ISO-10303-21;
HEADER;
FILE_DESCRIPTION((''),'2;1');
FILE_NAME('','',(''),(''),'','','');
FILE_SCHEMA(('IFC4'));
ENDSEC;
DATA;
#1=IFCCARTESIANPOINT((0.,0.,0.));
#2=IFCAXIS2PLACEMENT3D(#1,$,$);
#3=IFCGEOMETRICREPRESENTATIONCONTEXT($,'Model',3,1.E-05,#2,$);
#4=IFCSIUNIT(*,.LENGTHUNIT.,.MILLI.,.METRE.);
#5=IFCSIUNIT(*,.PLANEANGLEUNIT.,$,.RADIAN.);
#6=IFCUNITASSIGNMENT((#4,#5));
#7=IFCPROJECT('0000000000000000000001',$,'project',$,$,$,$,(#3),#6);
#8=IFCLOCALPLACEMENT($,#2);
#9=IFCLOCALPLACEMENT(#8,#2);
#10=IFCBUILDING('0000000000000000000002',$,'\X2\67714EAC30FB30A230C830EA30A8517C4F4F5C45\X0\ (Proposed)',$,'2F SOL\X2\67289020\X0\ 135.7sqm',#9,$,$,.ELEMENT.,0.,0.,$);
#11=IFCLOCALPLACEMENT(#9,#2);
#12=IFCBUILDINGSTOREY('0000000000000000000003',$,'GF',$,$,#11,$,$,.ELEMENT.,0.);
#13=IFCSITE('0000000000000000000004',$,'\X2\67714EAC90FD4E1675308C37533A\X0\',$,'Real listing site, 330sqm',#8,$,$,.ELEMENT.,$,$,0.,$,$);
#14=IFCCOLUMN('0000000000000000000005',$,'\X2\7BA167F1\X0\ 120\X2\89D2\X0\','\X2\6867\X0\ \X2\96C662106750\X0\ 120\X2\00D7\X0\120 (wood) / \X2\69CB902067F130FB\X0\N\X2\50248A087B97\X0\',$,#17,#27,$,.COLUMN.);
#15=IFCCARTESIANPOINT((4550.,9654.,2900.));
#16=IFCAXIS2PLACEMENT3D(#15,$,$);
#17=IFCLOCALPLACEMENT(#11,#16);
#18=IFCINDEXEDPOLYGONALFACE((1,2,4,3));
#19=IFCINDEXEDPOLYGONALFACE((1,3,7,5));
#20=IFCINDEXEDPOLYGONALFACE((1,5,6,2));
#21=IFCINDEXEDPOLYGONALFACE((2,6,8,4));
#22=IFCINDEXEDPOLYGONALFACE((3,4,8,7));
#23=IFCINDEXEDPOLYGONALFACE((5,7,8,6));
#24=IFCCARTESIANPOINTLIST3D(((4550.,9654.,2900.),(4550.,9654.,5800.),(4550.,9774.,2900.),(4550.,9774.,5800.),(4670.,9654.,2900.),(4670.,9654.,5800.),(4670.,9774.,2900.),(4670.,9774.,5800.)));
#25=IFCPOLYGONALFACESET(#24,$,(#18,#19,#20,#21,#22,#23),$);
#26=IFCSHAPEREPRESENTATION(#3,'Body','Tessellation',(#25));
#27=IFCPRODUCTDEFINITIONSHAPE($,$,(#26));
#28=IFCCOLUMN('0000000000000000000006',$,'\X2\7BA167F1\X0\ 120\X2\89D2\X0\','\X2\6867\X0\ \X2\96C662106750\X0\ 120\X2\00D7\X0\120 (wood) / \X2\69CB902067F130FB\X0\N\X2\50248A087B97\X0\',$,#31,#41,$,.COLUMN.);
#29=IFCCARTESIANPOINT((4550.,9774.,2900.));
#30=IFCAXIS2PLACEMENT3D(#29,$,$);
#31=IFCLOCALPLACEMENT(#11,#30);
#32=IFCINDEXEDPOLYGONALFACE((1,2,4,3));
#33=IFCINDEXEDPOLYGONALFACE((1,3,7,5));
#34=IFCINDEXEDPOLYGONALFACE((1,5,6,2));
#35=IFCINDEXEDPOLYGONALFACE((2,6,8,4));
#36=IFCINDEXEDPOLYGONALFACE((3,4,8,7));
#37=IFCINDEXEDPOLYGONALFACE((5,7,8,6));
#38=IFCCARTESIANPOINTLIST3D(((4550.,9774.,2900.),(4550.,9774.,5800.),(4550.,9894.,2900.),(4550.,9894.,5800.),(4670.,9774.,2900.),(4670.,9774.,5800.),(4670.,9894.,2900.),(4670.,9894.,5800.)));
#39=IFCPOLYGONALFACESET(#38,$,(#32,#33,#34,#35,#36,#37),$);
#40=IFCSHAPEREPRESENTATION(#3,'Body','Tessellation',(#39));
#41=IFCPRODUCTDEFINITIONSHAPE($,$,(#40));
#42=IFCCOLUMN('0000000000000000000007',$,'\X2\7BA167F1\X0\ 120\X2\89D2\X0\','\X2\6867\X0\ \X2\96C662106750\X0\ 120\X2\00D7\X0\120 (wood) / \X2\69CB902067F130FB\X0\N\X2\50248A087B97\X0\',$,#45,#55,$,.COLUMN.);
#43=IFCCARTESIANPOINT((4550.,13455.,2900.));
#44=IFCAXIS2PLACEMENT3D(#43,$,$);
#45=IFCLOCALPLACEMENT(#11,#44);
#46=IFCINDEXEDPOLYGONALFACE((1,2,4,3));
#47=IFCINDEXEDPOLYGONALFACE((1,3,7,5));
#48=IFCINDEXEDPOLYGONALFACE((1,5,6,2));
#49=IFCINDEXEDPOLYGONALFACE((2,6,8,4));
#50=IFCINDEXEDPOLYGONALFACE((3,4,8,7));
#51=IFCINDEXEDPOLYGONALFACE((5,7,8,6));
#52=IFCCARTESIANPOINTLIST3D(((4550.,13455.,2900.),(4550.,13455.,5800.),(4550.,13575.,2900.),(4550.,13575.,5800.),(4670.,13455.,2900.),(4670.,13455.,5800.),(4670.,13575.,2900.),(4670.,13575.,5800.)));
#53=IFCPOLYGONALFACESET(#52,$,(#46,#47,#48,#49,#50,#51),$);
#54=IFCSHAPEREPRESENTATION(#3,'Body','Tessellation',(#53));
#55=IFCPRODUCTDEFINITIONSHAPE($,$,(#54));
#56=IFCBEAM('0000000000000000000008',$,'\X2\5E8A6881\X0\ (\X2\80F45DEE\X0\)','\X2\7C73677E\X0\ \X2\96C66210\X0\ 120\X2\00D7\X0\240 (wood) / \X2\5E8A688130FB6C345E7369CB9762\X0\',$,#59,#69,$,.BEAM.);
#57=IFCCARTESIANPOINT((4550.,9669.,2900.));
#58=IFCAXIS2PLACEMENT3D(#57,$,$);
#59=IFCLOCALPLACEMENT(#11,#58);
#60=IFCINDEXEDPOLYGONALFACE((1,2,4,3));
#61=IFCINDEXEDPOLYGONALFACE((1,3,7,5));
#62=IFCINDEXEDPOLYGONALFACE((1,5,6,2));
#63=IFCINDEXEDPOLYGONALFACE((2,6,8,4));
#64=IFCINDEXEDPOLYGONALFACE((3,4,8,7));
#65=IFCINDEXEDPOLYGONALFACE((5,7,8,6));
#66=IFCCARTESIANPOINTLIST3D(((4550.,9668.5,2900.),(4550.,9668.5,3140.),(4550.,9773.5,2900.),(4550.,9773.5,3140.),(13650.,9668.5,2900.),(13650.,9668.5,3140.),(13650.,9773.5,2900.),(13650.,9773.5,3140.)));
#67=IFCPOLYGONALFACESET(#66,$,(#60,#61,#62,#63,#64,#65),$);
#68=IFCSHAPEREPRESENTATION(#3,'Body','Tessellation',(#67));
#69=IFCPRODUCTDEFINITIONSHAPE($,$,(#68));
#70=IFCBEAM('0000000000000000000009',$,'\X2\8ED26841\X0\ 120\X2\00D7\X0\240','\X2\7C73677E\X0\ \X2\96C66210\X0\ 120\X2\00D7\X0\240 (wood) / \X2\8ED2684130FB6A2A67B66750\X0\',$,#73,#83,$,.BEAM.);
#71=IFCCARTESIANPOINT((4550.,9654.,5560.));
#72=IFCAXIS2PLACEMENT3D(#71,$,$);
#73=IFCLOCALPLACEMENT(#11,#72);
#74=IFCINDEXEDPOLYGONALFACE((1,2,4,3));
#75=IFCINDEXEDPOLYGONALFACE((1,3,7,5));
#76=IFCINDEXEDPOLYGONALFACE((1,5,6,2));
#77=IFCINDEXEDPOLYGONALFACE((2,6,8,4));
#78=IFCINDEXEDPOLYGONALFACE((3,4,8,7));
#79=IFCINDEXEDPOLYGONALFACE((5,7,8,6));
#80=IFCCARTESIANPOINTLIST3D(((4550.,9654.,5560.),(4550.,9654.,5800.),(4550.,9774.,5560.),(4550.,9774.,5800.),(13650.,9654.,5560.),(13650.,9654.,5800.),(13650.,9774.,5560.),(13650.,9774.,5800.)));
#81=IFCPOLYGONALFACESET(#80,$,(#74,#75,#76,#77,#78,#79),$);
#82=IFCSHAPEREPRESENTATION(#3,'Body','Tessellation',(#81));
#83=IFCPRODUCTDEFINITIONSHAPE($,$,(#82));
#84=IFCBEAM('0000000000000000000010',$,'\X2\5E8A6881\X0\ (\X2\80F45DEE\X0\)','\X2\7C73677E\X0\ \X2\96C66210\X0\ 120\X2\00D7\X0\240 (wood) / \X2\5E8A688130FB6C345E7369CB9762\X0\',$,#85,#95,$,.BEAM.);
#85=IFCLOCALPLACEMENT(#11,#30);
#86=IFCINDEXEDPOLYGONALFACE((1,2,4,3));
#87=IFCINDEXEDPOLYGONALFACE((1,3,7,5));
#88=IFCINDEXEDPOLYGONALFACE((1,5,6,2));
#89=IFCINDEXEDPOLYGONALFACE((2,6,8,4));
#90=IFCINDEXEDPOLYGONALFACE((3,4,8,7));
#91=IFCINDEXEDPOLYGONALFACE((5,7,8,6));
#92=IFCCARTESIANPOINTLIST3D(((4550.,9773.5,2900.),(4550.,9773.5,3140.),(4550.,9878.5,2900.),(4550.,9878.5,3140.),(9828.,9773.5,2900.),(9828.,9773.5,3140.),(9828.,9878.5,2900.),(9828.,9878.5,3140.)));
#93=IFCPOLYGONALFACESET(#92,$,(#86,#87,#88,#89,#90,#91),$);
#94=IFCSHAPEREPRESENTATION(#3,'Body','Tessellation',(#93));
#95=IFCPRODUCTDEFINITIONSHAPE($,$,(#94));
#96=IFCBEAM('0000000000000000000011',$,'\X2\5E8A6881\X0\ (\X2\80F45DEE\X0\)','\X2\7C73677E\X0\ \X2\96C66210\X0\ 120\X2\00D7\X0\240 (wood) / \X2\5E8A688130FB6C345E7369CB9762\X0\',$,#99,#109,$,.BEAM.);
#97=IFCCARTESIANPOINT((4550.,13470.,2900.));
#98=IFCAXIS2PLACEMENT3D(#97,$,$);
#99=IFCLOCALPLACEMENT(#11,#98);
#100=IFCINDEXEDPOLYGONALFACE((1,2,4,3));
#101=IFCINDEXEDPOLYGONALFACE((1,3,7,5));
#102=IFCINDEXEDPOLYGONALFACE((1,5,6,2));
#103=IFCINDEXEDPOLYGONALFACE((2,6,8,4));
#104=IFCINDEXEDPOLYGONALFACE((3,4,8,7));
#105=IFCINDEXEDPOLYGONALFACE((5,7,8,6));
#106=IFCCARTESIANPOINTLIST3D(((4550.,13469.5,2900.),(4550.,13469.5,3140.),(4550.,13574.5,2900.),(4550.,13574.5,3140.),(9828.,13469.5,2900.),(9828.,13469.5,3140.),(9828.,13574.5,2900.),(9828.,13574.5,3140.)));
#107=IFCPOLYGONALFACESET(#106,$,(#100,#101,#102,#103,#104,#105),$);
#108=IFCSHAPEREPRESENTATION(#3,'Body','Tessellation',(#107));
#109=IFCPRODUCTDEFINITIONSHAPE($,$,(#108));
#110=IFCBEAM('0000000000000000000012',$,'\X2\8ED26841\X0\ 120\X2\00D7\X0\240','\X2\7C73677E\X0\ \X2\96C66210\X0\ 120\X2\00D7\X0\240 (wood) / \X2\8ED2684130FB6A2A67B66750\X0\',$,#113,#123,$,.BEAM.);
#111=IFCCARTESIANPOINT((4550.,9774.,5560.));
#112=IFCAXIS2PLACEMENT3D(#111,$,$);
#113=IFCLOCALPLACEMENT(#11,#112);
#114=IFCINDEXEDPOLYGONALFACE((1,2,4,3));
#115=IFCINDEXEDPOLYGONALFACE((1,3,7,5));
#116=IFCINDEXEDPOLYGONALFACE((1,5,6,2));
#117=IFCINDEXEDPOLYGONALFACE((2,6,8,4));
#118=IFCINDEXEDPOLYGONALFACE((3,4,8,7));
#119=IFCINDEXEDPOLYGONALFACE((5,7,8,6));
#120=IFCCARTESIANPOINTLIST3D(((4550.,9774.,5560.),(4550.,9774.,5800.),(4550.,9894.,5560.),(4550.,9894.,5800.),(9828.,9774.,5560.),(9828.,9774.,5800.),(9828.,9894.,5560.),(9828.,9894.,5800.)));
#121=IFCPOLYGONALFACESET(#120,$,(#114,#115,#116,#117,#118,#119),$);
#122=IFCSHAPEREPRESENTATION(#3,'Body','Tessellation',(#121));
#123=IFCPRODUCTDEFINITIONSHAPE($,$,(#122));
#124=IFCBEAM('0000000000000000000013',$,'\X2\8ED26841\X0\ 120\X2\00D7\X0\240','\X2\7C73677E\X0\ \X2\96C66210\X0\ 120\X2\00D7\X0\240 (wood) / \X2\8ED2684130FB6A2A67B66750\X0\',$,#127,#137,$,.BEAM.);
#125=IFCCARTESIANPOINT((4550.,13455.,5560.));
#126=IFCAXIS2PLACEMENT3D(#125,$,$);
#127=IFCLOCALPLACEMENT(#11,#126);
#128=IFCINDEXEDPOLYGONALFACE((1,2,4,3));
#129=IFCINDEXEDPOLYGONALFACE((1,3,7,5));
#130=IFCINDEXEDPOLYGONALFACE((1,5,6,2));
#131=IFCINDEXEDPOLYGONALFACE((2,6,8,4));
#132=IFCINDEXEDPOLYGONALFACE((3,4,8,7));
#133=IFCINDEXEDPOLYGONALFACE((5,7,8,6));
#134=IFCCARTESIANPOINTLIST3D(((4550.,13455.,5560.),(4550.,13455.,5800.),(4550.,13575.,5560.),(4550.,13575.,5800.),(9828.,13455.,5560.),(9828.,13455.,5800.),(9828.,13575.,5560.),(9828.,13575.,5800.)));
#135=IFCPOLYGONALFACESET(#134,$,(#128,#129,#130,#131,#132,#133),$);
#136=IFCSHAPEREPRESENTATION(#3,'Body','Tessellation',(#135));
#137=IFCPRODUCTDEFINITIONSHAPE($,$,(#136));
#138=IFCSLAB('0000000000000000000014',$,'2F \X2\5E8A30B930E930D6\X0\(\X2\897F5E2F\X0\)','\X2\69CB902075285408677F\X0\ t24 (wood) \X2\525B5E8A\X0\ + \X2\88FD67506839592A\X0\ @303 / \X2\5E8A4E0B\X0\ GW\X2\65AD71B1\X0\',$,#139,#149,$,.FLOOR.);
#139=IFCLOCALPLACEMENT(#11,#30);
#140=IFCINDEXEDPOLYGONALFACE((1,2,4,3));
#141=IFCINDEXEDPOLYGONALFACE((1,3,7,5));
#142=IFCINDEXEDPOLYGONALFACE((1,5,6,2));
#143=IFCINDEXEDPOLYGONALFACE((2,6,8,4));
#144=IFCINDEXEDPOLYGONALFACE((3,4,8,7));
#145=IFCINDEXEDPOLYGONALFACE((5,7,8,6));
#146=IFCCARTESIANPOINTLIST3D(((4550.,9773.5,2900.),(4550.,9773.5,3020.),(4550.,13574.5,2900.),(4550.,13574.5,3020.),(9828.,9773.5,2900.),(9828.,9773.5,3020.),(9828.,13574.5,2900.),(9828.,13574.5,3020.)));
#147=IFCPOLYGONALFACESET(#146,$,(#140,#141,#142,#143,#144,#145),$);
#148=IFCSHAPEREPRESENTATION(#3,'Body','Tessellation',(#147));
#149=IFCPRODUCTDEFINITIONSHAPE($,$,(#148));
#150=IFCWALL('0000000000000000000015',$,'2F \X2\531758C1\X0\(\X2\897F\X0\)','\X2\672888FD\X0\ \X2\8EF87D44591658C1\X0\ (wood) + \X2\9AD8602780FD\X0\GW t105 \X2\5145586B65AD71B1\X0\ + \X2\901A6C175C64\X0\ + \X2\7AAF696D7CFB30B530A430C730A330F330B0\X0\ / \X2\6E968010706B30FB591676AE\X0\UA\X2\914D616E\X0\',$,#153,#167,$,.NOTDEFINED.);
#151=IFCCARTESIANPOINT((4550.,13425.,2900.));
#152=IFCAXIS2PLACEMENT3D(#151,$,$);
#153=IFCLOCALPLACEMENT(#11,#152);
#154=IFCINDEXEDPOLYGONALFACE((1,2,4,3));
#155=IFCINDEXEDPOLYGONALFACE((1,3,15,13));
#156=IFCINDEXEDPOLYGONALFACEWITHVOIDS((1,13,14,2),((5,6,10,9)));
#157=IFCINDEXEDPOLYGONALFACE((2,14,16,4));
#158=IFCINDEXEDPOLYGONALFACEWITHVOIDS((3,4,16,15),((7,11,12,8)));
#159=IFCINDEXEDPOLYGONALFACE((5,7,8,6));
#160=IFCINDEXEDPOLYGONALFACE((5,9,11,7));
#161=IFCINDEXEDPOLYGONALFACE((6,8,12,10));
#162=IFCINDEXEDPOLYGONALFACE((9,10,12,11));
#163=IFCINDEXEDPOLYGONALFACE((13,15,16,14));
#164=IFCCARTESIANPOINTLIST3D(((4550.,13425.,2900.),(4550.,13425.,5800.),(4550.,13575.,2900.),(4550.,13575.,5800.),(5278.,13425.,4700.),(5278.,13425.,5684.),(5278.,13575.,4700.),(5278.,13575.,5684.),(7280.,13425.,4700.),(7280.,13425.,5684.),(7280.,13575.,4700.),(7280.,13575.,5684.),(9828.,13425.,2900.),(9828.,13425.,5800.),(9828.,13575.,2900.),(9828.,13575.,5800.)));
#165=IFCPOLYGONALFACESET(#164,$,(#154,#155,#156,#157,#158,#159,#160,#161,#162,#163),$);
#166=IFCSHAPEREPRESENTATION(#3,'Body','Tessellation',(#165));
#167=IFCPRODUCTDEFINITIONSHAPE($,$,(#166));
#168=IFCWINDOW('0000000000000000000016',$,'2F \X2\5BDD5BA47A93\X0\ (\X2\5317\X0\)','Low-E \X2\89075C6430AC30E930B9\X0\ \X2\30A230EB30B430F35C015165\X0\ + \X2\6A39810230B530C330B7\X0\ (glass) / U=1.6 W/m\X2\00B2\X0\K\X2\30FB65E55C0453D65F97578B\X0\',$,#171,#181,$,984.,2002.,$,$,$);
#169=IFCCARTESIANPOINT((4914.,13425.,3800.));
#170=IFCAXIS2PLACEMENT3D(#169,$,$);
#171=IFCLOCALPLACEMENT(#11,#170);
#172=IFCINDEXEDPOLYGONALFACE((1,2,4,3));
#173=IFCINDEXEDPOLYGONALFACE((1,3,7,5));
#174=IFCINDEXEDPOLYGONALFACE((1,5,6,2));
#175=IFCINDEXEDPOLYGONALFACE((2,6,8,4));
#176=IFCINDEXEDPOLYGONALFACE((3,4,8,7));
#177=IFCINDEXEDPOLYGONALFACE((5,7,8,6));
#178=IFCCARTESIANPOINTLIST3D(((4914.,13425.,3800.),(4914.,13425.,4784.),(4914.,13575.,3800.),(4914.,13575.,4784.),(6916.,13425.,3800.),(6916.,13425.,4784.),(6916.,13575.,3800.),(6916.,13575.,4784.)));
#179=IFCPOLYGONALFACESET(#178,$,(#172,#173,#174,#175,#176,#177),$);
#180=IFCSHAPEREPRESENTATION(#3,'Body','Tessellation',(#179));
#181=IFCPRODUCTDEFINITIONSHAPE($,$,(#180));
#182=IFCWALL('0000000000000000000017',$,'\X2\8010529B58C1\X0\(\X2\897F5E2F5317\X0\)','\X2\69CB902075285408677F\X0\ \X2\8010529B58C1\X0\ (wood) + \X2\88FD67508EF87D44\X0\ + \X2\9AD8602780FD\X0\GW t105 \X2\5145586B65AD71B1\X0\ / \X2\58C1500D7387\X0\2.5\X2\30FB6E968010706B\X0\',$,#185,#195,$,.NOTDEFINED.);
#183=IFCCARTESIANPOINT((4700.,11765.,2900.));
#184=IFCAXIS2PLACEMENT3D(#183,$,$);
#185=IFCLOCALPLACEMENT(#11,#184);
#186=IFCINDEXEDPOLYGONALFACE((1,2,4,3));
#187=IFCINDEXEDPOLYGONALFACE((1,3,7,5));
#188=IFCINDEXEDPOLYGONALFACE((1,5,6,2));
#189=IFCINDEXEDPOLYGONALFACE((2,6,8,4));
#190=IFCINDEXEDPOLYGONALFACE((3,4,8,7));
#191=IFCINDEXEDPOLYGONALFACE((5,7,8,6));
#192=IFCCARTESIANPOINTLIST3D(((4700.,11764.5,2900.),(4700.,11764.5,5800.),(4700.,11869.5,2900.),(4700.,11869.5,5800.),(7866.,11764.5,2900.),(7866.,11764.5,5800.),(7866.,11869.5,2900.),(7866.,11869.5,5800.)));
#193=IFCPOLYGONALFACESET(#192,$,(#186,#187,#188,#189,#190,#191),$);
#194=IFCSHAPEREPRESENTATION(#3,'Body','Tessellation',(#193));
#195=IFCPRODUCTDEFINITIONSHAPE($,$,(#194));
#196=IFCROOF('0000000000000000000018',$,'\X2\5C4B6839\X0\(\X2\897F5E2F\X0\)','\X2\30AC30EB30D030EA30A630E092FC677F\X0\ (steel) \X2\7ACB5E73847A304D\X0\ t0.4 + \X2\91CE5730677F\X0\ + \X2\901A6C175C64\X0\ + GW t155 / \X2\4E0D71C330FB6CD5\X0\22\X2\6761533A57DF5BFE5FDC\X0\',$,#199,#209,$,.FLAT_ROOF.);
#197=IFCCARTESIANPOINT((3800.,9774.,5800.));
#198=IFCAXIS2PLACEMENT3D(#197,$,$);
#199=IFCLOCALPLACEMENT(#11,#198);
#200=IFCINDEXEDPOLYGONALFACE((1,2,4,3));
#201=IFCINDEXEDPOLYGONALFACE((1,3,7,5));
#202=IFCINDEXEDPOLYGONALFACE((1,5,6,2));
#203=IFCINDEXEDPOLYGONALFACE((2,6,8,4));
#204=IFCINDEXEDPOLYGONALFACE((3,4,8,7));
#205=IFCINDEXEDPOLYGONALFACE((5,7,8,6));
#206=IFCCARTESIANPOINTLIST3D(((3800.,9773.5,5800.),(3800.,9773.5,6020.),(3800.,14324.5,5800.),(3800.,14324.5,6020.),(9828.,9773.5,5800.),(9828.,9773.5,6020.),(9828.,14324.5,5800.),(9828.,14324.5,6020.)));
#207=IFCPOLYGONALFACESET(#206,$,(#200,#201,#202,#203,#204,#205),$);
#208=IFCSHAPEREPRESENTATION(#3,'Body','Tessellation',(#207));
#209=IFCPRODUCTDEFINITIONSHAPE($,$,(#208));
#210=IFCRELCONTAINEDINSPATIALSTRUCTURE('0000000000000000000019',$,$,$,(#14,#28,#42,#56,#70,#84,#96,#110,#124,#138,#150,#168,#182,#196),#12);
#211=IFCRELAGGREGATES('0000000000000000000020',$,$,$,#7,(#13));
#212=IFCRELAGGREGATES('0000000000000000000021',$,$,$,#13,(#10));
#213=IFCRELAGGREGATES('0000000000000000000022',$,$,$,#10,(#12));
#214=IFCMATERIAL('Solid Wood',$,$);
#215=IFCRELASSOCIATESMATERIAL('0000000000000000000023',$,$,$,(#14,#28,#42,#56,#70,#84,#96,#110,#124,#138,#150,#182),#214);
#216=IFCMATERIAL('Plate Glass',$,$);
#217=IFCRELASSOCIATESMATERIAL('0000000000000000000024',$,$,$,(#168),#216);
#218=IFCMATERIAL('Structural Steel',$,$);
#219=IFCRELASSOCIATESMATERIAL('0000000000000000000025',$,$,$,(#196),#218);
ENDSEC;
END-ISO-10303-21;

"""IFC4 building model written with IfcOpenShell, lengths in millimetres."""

from ifc_helpers import new_model, si_unit, frame, frame_2d, origin, place, context, project, spatial, rectangle, extrude, material, element, fill, save


model = new_model("IFC4")

# Units and contexts
model_context = context("Model", 3, precision=1e-05, world=origin())
ifc_project = project(units=[si_unit("LENGTHUNIT", "METRE", prefix="MILLI"), si_unit("PLANEANGLEUNIT", "RADIAN")], contexts=[model_context])

# Site, building, storey
site_placement = place(None, origin())
site = spatial("IfcSite", under=ifc_project, at=site_placement, Name="東京都世田谷区", ObjectType="Real listing site, 330sqm", CompositionType="ELEMENT", RefElevation=0.0)
building_placement = place(site_placement, origin())
building = spatial("IfcBuilding", under=site, at=building_placement, Name="東京・アトリエ兼住居 (Proposed)", ObjectType="2F SOL木造 135.7sqm", CompositionType="ELEMENT", ElevationOfRefHeight=0.0, ElevationOfTerrain=0.0)
storey_placement = place(building_placement, origin())
storey = spatial("IfcBuildingStorey", under=building, at=storey_placement, Name="GF", CompositionType="ELEMENT", Elevation=0.0)

# Columns
ifc_material_1 = material(Name="Solid Wood")
column_1_placement = place(storey_placement, frame((4550.0, 9654.0, 2900.0)))
element("IfcColumn", 1, at=column_1_placement, inside=storey, material=ifc_material_1, Name="管柱 120角", Description="桧 集成材 120×120 (wood) / 構造柱・N値計算", PredefinedType="COLUMN", context=model_context, shape_type="SweptSolid", body=[
    extrude(rectangle(XDim=120.0, YDim=120.0, at=frame_2d((60.0, 60.0))), frame((4550.0, 9654.0, 2900.0)), (0.0, 0.0, 1.0), 2900.0),
])
column_2_placement = place(storey_placement, frame((4550.0, 9774.0, 2900.0)))
element("IfcColumn", 2, at=column_2_placement, inside=storey, material=ifc_material_1, Name="管柱 120角", Description="桧 集成材 120×120 (wood) / 構造柱・N値計算", PredefinedType="COLUMN", context=model_context, shape_type="SweptSolid", body=[
    extrude(rectangle(XDim=120.0, YDim=120.0, at=frame_2d((60.0, 60.0))), frame((4550.0, 9774.0, 2900.0)), (0.0, 0.0, 1.0), 2900.0),
])
column_3_placement = place(storey_placement, frame((4550.0, 13455.0, 2900.0)))
element("IfcColumn", 3, at=column_3_placement, inside=storey, material=ifc_material_1, Name="管柱 120角", Description="桧 集成材 120×120 (wood) / 構造柱・N値計算", PredefinedType="COLUMN", context=model_context, shape_type="SweptSolid", body=[
    extrude(rectangle(XDim=120.0, YDim=120.0, at=frame_2d((60.0, 60.0))), frame((4550.0, 13455.0, 2900.0)), (0.0, 0.0, 1.0), 2900.0),
])

# Beams
beam_1_placement = place(storey_placement, frame((4550.0, 9669.0, 2900.0)))
element("IfcBeam", 4, at=beam_1_placement, inside=storey, material=ifc_material_1, Name="床梁 (胴差)", Description="米松 集成 120×240 (wood) / 床梁・水平構面", PredefinedType="BEAM", context=model_context, shape_type="SweptSolid", body=[
    extrude(rectangle(XDim=9100.0, YDim=105.0, at=frame_2d((4550.0, 52.0))), frame((4550.0, 9669.0, 2900.0)), (0.0, 0.0, 1.0), 240.0),
])
beam_2_placement = place(storey_placement, frame((4550.0, 9654.0, 5560.0)))
element("IfcBeam", 5, at=beam_2_placement, inside=storey, material=ifc_material_1, Name="軒桁 120×240", Description="米松 集成 120×240 (wood) / 軒桁・横架材", PredefinedType="BEAM", context=model_context, shape_type="SweptSolid", body=[
    extrude(rectangle(XDim=9100.0, YDim=120.0, at=frame_2d((4550.0, 60.0))), frame((4550.0, 9654.0, 5560.0)), (0.0, 0.0, 1.0), 240.0),
])
beam_3_placement = place(storey_placement, frame((4550.0, 9774.0, 2900.0)))
element("IfcBeam", 6, at=beam_3_placement, inside=storey, material=ifc_material_1, Name="床梁 (胴差)", Description="米松 集成 120×240 (wood) / 床梁・水平構面", PredefinedType="BEAM", context=model_context, shape_type="SweptSolid", body=[
    extrude(rectangle(XDim=5278.0, YDim=105.0, at=frame_2d((2639.0, 52.0))), frame((4550.0, 9774.0, 2900.0)), (0.0, 0.0, 1.0), 240.0),
])
beam_4_placement = place(storey_placement, frame((4550.0, 13470.0, 2900.0)))
element("IfcBeam", 7, at=beam_4_placement, inside=storey, material=ifc_material_1, Name="床梁 (胴差)", Description="米松 集成 120×240 (wood) / 床梁・水平構面", PredefinedType="BEAM", context=model_context, shape_type="SweptSolid", body=[
    extrude(rectangle(XDim=5278.0, YDim=105.0, at=frame_2d((2639.0, 52.0))), frame((4550.0, 13470.0, 2900.0)), (0.0, 0.0, 1.0), 240.0),
])
beam_5_placement = place(storey_placement, frame((4550.0, 9774.0, 5560.0)))
element("IfcBeam", 8, at=beam_5_placement, inside=storey, material=ifc_material_1, Name="軒桁 120×240", Description="米松 集成 120×240 (wood) / 軒桁・横架材", PredefinedType="BEAM", context=model_context, shape_type="SweptSolid", body=[
    extrude(rectangle(XDim=5278.0, YDim=120.0, at=frame_2d((2639.0, 60.0))), frame((4550.0, 9774.0, 5560.0)), (0.0, 0.0, 1.0), 240.0),
])
beam_6_placement = place(storey_placement, frame((4550.0, 13455.0, 5560.0)))
element("IfcBeam", 9, at=beam_6_placement, inside=storey, material=ifc_material_1, Name="軒桁 120×240", Description="米松 集成 120×240 (wood) / 軒桁・横架材", PredefinedType="BEAM", context=model_context, shape_type="SweptSolid", body=[
    extrude(rectangle(XDim=5278.0, YDim=120.0, at=frame_2d((2639.0, 60.0))), frame((4550.0, 13455.0, 5560.0)), (0.0, 0.0, 1.0), 240.0),
])

# Slab
slab_placement = place(storey_placement, frame((4550.0, 9774.0, 2900.0)))
element("IfcSlab", 10, at=slab_placement, inside=storey, material=ifc_material_1, Name="2F 床スラブ(西帯)", Description="構造用合板 t24 (wood) 剛床 + 製材根太 @303 / 床下 GW断熱", PredefinedType="FLOOR", context=model_context, shape_type="SweptSolid", body=[
    extrude(rectangle(XDim=5278.0, YDim=3801.0, at=frame_2d((2639.0, 1900.0))), frame((4550.0, 9774.0, 2900.0)), (0.0, 0.0, 1.0), 120.0),
])

# Wall, opening, window
wall_1_placement = place(storey_placement, frame((4550.0, 13425.0, 2900.0)))
wall_1 = element("IfcWall", 11, at=wall_1_placement, inside=storey, material=ifc_material_1, Name="2F 北壁(西)", Description="木製 軸組外壁 (wood) + 高性能GW t105 充填断熱 + 通気層 + 窯業系サイディング / 準耐火・外皮UA配慮", PredefinedType="NOTDEFINED", context=model_context, shape_type="SweptSolid", body=[
    extrude(rectangle(XDim=5278.0, YDim=150.0, at=frame_2d((2639.0, 75.0))), frame((4550.0, 13425.0, 2900.0)), (0.0, 0.0, 1.0), 2900.0),
])
opening_placement = place(storey_placement, frame((4914.0, 13425.0, 3800.0)))
opening = element("IfcOpeningElement", 12, at=opening_placement, cuts=wall_1, PredefinedType="NOTDEFINED", context=model_context, shape_type="SweptSolid", body=[
    extrude(rectangle(XDim=2002.0, YDim=150.0, at=frame_2d((1001.0, 75.0))), frame((4914.0, 13425.0, 3800.0)), (0.0, 0.0, 1.0), 984.0),
])
ifc_material_2 = material(Name="Plate Glass")
window_placement = place(storey_placement, frame((4914.0, 13425.0, 3800.0)))
window = element("IfcWindow", 13, at=window_placement, inside=storey, material=ifc_material_2, Name="2F 寝室窓 (北)", Description="Low-E 複層ガラス アルゴン封入 + 樹脂サッシ (glass) / U=1.6 W/m²K・日射取得型", OverallHeight=984.0, OverallWidth=2002.0, context=model_context, shape_type="SweptSolid", body=[
    extrude(rectangle(XDim=2002.0, YDim=150.0, at=frame_2d((1001.0, 75.0))), frame((4914.0, 13425.0, 3800.0)), (0.0, 0.0, 1.0), 984.0),
])
fill(opening, window)

# Wall
wall_2_placement = place(storey_placement, frame((4700.0, 11765.0, 2900.0)))
element("IfcWall", 14, at=wall_2_placement, inside=storey, material=ifc_material_1, Name="耐力壁(西帯北)", Description="構造用合板 耐力壁 (wood) + 製材軸組 + 高性能GW t105 充填断熱 / 壁倍率2.5・準耐火", PredefinedType="NOTDEFINED", context=model_context, shape_type="SweptSolid", body=[
    extrude(rectangle(XDim=3166.0, YDim=105.0, at=frame_2d((1583.0, 52.0))), frame((4700.0, 11765.0, 2900.0)), (0.0, 0.0, 1.0), 2900.0),
])

# Roof
ifc_material_3 = material(Name="Structural Steel")
for number, where, name in (
    (15, (3800.0, 9774.0, 5800.0), "屋根(西帯)"),
):
    element("IfcRoof", number, at=place(storey_placement, frame(where)), inside=storey, material=ifc_material_3, Name=name, Description="ガルバリウム鋼板 (steel) 立平葺き t0.4 + 野地板 + 通気層 + GW t155 / 不燃・法22条区域対応", PredefinedType="FLAT_ROOF", context=model_context, shape_type="SweptSolid", body=[
        extrude(rectangle(XDim=6028.0, YDim=4551.0, at=frame_2d((3014.0, 2275.0))), frame((3800.0, 9774.0, 5800.0)), (0.0, 0.0, 1.0), 220.0),
    ])

save(model, "model.ifc")
